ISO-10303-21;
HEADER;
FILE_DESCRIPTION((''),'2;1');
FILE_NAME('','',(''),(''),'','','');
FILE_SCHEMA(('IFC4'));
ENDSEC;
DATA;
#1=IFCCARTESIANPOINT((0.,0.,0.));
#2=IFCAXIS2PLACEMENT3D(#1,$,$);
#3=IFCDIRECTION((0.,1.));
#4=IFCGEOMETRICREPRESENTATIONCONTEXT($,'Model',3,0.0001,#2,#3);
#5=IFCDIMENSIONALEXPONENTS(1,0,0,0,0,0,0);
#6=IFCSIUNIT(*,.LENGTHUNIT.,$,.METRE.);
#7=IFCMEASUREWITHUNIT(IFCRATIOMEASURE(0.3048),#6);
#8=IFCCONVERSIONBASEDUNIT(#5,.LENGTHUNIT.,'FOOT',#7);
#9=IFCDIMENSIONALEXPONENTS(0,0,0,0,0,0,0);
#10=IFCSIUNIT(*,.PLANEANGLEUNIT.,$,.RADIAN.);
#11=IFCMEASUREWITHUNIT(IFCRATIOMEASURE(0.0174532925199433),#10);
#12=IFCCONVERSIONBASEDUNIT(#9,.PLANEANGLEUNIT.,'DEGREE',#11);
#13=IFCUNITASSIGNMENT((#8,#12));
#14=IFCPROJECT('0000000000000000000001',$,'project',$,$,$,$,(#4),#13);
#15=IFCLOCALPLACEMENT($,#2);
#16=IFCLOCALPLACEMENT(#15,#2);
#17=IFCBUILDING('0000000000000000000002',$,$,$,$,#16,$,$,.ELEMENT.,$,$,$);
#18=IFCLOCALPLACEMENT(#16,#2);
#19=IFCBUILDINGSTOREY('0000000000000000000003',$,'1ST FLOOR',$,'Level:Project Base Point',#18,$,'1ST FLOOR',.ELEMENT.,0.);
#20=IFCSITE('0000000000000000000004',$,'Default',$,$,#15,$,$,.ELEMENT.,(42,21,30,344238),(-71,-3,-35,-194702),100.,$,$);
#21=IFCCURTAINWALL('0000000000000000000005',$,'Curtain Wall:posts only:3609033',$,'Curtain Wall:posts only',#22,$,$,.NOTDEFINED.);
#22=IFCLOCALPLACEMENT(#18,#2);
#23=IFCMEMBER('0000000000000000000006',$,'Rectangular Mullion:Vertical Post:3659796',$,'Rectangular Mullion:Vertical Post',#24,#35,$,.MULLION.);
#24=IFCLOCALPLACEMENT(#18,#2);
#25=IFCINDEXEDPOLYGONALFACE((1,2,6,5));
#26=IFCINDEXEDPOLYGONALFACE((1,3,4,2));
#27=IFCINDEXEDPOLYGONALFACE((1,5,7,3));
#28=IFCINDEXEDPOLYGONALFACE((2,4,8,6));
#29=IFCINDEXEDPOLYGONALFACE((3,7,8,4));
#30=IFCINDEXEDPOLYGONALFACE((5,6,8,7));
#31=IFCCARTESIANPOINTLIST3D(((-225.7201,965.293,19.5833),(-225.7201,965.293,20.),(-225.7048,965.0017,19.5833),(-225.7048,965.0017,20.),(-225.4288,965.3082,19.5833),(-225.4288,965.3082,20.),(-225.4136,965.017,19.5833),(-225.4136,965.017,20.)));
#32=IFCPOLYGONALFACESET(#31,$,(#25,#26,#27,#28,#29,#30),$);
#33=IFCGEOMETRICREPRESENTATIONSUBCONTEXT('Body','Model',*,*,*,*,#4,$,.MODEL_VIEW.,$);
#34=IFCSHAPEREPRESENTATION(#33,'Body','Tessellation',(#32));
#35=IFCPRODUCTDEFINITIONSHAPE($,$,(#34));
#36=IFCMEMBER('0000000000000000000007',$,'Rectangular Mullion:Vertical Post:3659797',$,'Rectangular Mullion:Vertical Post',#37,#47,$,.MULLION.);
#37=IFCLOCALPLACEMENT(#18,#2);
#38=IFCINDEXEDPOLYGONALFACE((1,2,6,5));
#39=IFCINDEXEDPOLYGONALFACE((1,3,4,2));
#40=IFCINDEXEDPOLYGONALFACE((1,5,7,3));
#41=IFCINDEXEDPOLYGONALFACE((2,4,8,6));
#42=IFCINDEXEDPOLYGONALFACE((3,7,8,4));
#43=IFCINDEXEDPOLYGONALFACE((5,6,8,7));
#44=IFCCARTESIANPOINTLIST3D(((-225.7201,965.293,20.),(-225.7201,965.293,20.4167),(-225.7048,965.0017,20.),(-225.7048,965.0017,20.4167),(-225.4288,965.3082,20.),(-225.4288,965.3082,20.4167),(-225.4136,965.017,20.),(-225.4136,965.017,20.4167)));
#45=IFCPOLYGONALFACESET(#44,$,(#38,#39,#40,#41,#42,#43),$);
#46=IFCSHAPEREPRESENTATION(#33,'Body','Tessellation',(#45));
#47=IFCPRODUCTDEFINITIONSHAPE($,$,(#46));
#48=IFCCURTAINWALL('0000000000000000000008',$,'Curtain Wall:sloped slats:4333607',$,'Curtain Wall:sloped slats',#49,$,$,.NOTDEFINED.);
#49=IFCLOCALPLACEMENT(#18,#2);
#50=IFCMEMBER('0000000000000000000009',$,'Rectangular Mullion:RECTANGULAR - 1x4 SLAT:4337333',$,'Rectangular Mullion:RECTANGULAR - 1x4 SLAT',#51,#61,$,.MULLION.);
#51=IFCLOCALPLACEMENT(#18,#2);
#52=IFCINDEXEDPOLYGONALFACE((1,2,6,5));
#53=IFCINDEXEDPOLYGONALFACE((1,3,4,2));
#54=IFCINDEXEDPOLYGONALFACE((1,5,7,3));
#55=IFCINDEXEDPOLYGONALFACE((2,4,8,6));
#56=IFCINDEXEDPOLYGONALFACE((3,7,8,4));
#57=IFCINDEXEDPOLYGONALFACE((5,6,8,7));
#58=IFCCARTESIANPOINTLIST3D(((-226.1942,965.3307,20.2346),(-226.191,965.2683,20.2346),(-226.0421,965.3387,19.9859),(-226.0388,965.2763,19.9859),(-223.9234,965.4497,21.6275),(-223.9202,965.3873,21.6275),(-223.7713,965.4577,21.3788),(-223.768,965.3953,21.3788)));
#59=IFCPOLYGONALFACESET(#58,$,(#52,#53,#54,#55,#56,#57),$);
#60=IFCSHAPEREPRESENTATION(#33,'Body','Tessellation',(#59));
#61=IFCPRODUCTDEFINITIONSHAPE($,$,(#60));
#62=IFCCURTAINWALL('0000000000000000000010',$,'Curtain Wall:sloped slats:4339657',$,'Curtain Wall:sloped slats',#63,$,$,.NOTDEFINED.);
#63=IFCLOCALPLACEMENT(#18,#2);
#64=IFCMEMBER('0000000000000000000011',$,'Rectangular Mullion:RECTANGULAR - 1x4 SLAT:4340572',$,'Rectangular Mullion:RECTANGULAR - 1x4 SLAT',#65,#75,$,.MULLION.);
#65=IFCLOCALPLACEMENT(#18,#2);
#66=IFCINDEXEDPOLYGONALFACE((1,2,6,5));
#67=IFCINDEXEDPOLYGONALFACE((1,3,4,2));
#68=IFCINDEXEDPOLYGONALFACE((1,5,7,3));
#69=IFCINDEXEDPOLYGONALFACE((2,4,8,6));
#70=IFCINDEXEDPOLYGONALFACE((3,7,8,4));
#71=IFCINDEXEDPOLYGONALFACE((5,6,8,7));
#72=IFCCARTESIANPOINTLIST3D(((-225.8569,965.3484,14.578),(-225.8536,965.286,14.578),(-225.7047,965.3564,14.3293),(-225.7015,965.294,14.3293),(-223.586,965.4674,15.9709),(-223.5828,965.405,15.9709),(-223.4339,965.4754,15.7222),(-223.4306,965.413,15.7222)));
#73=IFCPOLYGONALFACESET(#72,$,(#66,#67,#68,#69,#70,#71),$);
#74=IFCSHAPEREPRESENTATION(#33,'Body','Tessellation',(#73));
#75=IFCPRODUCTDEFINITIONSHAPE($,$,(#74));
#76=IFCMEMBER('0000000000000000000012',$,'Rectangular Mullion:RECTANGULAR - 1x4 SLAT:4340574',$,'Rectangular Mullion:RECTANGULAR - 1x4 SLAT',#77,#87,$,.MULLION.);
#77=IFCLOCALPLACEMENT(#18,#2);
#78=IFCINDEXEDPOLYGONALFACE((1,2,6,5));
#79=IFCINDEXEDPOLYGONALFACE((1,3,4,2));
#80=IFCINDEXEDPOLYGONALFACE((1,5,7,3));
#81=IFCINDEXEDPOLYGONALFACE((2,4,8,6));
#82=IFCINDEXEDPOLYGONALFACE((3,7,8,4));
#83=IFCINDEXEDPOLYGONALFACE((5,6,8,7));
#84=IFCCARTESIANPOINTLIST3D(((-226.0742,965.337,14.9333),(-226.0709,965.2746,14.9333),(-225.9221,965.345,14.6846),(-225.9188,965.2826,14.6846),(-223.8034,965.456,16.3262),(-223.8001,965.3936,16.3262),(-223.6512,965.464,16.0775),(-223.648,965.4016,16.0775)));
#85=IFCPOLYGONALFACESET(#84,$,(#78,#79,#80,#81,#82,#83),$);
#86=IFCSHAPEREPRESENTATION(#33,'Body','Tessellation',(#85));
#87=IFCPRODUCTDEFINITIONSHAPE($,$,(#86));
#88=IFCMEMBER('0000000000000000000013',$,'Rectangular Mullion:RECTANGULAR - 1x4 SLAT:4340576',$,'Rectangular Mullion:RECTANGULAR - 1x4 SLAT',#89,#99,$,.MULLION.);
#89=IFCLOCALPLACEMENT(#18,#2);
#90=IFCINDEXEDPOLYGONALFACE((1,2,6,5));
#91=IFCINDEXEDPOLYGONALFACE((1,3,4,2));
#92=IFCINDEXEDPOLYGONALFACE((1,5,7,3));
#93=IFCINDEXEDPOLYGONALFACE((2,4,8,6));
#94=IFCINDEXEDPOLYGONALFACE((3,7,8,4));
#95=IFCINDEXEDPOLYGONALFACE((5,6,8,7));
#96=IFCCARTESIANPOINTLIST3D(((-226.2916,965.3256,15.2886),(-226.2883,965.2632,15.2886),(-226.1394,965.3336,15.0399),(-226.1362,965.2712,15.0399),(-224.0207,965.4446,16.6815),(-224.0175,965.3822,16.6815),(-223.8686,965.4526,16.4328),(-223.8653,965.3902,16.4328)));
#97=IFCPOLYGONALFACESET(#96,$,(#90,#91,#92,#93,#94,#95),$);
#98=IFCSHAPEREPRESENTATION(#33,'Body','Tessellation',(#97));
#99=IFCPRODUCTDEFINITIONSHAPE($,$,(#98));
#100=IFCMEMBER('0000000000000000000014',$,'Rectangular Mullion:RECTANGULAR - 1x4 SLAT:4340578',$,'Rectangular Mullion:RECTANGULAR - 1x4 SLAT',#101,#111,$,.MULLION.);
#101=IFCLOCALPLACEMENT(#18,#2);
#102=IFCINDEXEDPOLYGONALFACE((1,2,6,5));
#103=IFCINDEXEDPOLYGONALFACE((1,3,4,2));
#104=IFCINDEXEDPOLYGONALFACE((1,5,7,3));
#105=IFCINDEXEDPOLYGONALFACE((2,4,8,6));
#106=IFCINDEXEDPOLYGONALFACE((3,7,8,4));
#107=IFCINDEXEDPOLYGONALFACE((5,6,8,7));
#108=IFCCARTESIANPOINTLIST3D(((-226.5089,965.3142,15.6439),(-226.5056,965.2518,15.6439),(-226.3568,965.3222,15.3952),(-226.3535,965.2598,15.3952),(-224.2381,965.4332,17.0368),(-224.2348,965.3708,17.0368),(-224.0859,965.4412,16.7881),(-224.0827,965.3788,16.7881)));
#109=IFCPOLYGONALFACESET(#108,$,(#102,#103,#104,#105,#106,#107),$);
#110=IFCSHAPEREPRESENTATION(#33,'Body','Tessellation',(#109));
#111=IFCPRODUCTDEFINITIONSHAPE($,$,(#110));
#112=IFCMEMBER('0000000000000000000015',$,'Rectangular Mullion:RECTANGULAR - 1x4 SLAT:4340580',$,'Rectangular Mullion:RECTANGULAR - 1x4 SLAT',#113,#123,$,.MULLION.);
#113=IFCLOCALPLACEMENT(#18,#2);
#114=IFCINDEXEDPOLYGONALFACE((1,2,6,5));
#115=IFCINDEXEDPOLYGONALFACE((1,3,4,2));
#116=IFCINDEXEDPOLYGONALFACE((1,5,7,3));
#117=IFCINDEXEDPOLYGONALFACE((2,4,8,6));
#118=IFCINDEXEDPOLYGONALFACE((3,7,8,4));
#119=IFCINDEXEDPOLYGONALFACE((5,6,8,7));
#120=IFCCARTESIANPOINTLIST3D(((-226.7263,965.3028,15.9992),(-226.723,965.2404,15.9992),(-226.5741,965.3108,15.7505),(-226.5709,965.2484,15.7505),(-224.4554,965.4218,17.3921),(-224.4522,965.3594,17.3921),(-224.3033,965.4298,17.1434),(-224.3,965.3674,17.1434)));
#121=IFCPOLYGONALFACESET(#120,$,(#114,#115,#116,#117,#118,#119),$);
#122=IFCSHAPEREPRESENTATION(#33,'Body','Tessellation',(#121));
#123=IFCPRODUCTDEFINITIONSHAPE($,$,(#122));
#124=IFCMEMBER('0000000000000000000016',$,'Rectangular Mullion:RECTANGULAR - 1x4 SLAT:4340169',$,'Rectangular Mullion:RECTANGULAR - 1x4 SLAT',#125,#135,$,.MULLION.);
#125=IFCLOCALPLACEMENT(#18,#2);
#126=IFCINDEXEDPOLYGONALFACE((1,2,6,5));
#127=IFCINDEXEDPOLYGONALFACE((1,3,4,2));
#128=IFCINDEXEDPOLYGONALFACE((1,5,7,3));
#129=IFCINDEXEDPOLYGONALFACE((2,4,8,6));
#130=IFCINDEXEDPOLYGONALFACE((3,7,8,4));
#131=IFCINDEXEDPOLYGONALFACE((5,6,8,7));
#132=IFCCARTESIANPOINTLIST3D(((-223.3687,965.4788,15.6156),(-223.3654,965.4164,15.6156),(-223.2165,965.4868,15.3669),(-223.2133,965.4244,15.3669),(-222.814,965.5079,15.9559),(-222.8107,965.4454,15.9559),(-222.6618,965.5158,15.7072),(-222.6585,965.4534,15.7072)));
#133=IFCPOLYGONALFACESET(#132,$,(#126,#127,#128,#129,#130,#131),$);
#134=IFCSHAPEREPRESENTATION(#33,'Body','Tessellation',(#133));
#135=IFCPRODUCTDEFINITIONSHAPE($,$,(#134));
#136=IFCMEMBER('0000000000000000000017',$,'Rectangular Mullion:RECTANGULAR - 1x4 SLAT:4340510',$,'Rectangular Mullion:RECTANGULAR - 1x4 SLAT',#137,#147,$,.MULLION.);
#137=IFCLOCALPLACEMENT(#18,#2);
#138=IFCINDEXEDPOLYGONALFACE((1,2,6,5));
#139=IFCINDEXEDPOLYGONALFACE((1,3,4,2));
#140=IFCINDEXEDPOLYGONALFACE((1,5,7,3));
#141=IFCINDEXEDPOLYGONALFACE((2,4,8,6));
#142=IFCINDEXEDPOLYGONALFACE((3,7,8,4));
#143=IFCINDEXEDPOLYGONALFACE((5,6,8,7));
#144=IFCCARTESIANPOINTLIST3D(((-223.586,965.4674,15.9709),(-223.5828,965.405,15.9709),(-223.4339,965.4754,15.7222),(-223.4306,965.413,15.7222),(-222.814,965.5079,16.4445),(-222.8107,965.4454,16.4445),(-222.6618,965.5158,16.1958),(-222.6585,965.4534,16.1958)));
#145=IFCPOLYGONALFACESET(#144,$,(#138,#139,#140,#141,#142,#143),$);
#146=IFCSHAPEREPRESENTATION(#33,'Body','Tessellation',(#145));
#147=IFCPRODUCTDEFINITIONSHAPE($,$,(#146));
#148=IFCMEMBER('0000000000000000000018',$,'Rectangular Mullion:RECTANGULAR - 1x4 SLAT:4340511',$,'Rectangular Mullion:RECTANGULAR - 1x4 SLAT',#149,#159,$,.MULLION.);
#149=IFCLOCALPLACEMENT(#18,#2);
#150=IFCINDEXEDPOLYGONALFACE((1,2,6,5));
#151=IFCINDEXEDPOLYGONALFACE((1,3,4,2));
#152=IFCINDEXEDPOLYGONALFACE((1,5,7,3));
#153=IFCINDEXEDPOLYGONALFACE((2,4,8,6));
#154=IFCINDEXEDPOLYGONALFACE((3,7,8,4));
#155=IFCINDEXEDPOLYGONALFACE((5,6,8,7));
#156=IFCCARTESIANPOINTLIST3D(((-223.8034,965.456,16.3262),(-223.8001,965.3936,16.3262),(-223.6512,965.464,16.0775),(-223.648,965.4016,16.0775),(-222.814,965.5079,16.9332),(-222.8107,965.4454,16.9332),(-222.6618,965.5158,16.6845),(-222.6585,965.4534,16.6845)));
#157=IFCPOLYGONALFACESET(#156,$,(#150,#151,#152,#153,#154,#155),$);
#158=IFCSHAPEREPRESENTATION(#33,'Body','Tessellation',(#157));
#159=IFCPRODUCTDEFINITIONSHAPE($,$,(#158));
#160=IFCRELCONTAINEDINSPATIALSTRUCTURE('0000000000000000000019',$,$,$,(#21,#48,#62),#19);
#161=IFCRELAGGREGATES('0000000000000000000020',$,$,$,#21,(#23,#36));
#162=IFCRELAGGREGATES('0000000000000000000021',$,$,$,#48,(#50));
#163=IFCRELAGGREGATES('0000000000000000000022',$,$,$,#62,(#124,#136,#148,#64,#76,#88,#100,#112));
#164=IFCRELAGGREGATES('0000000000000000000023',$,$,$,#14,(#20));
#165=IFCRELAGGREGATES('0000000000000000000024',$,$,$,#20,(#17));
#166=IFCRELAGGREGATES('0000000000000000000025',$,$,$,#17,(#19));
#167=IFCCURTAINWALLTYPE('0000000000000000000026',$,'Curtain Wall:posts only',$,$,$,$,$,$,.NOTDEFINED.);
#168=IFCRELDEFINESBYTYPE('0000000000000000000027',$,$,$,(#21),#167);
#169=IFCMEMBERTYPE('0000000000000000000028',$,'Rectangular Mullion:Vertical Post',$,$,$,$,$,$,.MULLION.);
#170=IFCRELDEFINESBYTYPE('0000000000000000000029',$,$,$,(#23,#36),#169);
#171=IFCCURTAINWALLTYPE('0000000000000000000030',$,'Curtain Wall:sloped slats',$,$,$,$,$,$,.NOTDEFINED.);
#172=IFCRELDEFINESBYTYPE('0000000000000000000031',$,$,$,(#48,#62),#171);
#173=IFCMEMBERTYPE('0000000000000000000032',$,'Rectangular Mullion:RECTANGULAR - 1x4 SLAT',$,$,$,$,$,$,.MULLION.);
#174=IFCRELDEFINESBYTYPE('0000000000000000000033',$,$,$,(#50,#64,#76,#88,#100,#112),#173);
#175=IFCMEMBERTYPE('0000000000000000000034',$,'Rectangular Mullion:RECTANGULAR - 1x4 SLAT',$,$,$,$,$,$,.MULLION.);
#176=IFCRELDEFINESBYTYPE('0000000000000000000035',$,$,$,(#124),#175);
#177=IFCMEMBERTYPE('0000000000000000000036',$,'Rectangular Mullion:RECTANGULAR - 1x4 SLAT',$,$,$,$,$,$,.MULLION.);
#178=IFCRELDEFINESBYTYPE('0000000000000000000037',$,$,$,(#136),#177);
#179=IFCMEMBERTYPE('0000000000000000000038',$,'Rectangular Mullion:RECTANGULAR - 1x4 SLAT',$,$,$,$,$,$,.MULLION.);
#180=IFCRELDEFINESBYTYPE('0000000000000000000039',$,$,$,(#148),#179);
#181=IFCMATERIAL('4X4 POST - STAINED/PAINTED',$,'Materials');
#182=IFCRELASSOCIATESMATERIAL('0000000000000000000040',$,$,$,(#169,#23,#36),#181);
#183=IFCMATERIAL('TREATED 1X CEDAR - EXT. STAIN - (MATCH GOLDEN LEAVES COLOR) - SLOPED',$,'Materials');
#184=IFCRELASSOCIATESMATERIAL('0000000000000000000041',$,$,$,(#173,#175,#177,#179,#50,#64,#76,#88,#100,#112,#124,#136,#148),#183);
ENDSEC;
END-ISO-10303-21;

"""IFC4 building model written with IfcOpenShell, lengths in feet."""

from ifc_helpers import new_model, entity, si_unit, converted_unit, direction, frame, frame_2d, origin, origin_2d_with_axis, place, context, subcontext, project, spatial, rectangle, extrude, source, transform, mapped, material, material_profile, profile_set, profile_usage, type_object, type_shapes, element, aggregate, save


model = new_model("IFC4")

# Units and contexts
model_context = context("Model", 3, precision=0.0001, world=origin(), true_north=direction((0.0, 1.0)))
body_context = subcontext(model_context, "Body", "Model", "MODEL_VIEW")
ifc_project = project(units=[converted_unit("LENGTHUNIT", "FOOT", entity("IfcRatioMeasure", 0.3048), si_unit("LENGTHUNIT", "METRE"), dimensions=[1, 0, 0, 0, 0, 0, 0]), converted_unit("PLANEANGLEUNIT", "DEGREE", entity("IfcRatioMeasure", 0.0174532925199433), si_unit("PLANEANGLEUNIT", "RADIAN"), dimensions=[0, 0, 0, 0, 0, 0, 0])], contexts=[model_context])

# Site, building, storey
site_placement = place(None, origin())
site = spatial("IfcSite", under=ifc_project, at=site_placement, Name="Default", CompositionType="ELEMENT", RefLatitude=(42, 21, 30, 344238), RefLongitude=(-71, -3, -35, -194702), RefElevation=100.0)
building_placement = place(site_placement, origin())
building = spatial("IfcBuilding", under=site, at=building_placement, CompositionType="ELEMENT")
storey_placement = place(building_placement, origin())
storey = spatial("IfcBuildingStorey", under=building, at=storey_placement, Name="1ST FLOOR", ObjectType="Level:Project Base Point", LongName="1ST FLOOR", CompositionType="ELEMENT", Elevation=0.0)

# Curtain wall, members
curtain_wall_type_1 = type_object("IfcCurtainWallType", Name="Curtain Wall:posts only", PredefinedType="NOTDEFINED")
curtain_wall_1_placement = place(storey_placement, origin())
curtain_wall_1 = element("IfcCurtainWall", 1, at=curtain_wall_1_placement, inside=storey, type_object=curtain_wall_type_1, Name="Curtain Wall:posts only:3609033", ObjectType="Curtain Wall:posts only", PredefinedType="NOTDEFINED")
ifc_material_1 = material(Name="4X4 POST - STAINED/PAINTED", Category="Materials")
ifc_material_profile_1 = material_profile(ifc_material_1, rectangle(XDim=0.2917, YDim=0.2917, at=origin_2d_with_axis()), Name="Vertical Post")
ifc_profile_set_1 = profile_set([ifc_material_profile_1], Name="Vertical Post")
member_type_1 = type_object("IfcMemberType", Name="Rectangular Mullion:Vertical Post", PredefinedType="MULLION", material=ifc_profile_set_1)
shared_shape_1 = source(origin(), body_context, "Body", "SweptSolid", [
    extrude(rectangle(XDim=0.2917, YDim=0.2917, at=origin_2d_with_axis()), frame((0.0, -0.2083, -0.4167), z_axis=(0.0, 0.0, 1.0), x_axis=(0.0, -1.0, 0.0)), (0.0, 0.0, 1.0), 0.4167),
])
type_shapes(member_type_1, [shared_shape_1])
ifc_profile_usage_1 = profile_usage(ifc_profile_set_1)
member_1_placement = place(storey_placement, frame((-225.5777, 965.363, 19.5833), z_axis=(0.0, 0.0, -1.0), x_axis=(-0.99863, -0.052336, 0.0)))
member_1 = element("IfcMember", 2, at=member_1_placement, type_object=member_type_1, material=ifc_profile_usage_1, Name="Rectangular Mullion:Vertical Post:3659796", ObjectType="Rectangular Mullion:Vertical Post", PredefinedType="MULLION", context=body_context, shape_type="MappedRepresentation", body=[
    mapped(shared_shape_1, transform((0.0, 0.0, 0.0), scale=1.0)),
])
ifc_profile_usage_2 = profile_usage(ifc_profile_set_1)
member_2_placement = place(storey_placement, frame((-225.5777, 965.363, 20.0), z_axis=(0.0, 0.0, -1.0), x_axis=(-0.99863, -0.052336, 0.0)))
member_2 = element("IfcMember", 3, at=member_2_placement, type_object=member_type_1, material=ifc_profile_usage_2, Name="Rectangular Mullion:Vertical Post:3659797", ObjectType="Rectangular Mullion:Vertical Post", PredefinedType="MULLION", context=body_context, shape_type="MappedRepresentation", body=[
    mapped(shared_shape_1, transform((0.0, 0.0, 0.0), scale=1.0)),
])
aggregate(curtain_wall_1, [member_1, member_2])

# Curtain wall, member
curtain_wall_type_2 = type_object("IfcCurtainWallType", Name="Curtain Wall:sloped slats", PredefinedType="NOTDEFINED")
curtain_wall_2_placement = place(storey_placement, origin())
curtain_wall_2 = element("IfcCurtainWall", 4, at=curtain_wall_2_placement, inside=storey, type_object=curtain_wall_type_2, Name="Curtain Wall:sloped slats:4333607", ObjectType="Curtain Wall:sloped slats", PredefinedType="NOTDEFINED")
ifc_material_2 = material(Name="TREATED 1X CEDAR - EXT. STAIN - (MATCH GOLDEN LEAVES COLOR) - SLOPED", Category="Materials")
ifc_material_profile_2 = material_profile(ifc_material_2, rectangle(XDim=0.0625, YDim=0.2917, at=frame_2d((0.0, 0.0), x_axis=(1.0, 0.0))), Name="RECTANGULAR - 1x4 SLAT")
ifc_profile_set_2 = profile_set([ifc_material_profile_2], Name="RECTANGULAR - 1x4 SLAT")
ifc_profile_usage_3 = profile_usage(ifc_profile_set_2)
member_type_2 = type_object("IfcMemberType", Name="Rectangular Mullion:RECTANGULAR - 1x4 SLAT", PredefinedType="MULLION", material=ifc_profile_set_2)
shared_shape_2 = source(origin(), body_context, "Body", "SweptSolid", [
    extrude(rectangle(XDim=0.0625, YDim=0.2917, at=frame_2d((0.0, 0.0), x_axis=(1.0, 0.0))), frame((0.0, 0.0, -2.6667), z_axis=(0.0, 0.0, 1.0), x_axis=(0.0, -1.0, 0.0)), (0.0, 0.0, 1.0), 2.6667),
])
type_shapes(member_type_2, [shared_shape_2])
member_3_placement = place(storey_placement, frame((-226.1165, 965.3035, 20.1102), z_axis=(-0.851559, -0.044628, -0.522356), x_axis=(-0.52164, -0.027338, 0.852727)))
member_3 = element("IfcMember", 5, at=member_3_placement, type_object=member_type_2, material=ifc_profile_usage_3, Name="Rectangular Mullion:RECTANGULAR - 1x4 SLAT:4337333", ObjectType="Rectangular Mullion:RECTANGULAR - 1x4 SLAT", PredefinedType="MULLION", context=body_context, shape_type="MappedRepresentation", body=[
    mapped(shared_shape_2, transform((0.0, 0.0, 0.0), scale=1.0)),
])
aggregate(curtain_wall_2, [member_3])

# Curtain wall, members
curtain_wall_3_placement = place(storey_placement, origin())
curtain_wall_3 = element("IfcCurtainWall", 6, at=curtain_wall_3_placement, inside=storey, type_object=curtain_wall_type_2, Name="Curtain Wall:sloped slats:4339657", ObjectType="Curtain Wall:sloped slats", PredefinedType="NOTDEFINED")
ifc_profile_usage_4 = profile_usage(ifc_profile_set_2)
member_4_placement = place(storey_placement, frame((-225.7792, 965.3212, 14.4536), z_axis=(-0.851559, -0.044628, -0.522356), x_axis=(-0.52164, -0.027338, 0.852727)))
member_4 = element("IfcMember", 7, at=member_4_placement, type_object=member_type_2, material=ifc_profile_usage_4, Name="Rectangular Mullion:RECTANGULAR - 1x4 SLAT:4340572", ObjectType="Rectangular Mullion:RECTANGULAR - 1x4 SLAT", PredefinedType="MULLION", context=body_context, shape_type="MappedRepresentation", body=[
    mapped(shared_shape_2, transform((0.0, 0.0, 0.0), scale=1.0)),
])
ifc_profile_usage_5 = profile_usage(ifc_profile_set_2)
member_5_placement = place(storey_placement, frame((-225.9965, 965.3098, 14.8089), z_axis=(-0.851559, -0.044628, -0.522356), x_axis=(-0.52164, -0.027338, 0.852727)))
member_5 = element("IfcMember", 8, at=member_5_placement, type_object=member_type_2, material=ifc_profile_usage_5, Name="Rectangular Mullion:RECTANGULAR - 1x4 SLAT:4340574", ObjectType="Rectangular Mullion:RECTANGULAR - 1x4 SLAT", PredefinedType="MULLION", context=body_context, shape_type="MappedRepresentation", body=[
    mapped(shared_shape_2, transform((0.0, 0.0, 0.0), scale=1.0)),
])
ifc_profile_usage_6 = profile_usage(ifc_profile_set_2)
member_6_placement = place(storey_placement, frame((-226.2139, 965.2984, 15.1642), z_axis=(-0.851559, -0.044628, -0.522356), x_axis=(-0.52164, -0.027338, 0.852727)))
member_6 = element("IfcMember", 9, at=member_6_placement, type_object=member_type_2, material=ifc_profile_usage_6, Name="Rectangular Mullion:RECTANGULAR - 1x4 SLAT:4340576", ObjectType="Rectangular Mullion:RECTANGULAR - 1x4 SLAT", PredefinedType="MULLION", context=body_context, shape_type="MappedRepresentation", body=[
    mapped(shared_shape_2, transform((0.0, 0.0, 0.0), scale=1.0)),
])
ifc_profile_usage_7 = profile_usage(ifc_profile_set_2)
member_7_placement = place(storey_placement, frame((-226.4312, 965.287, 15.5195), z_axis=(-0.851559, -0.044628, -0.522356), x_axis=(-0.52164, -0.027338, 0.852727)))
member_7 = element("IfcMember", 10, at=member_7_placement, type_object=member_type_2, material=ifc_profile_usage_7, Name="Rectangular Mullion:RECTANGULAR - 1x4 SLAT:4340578", ObjectType="Rectangular Mullion:RECTANGULAR - 1x4 SLAT", PredefinedType="MULLION", context=body_context, shape_type="MappedRepresentation", body=[
    mapped(shared_shape_2, transform((0.0, 0.0, 0.0), scale=1.0)),
])
ifc_profile_usage_8 = profile_usage(ifc_profile_set_2)
member_8_placement = place(storey_placement, frame((-226.6486, 965.2756, 15.8748), z_axis=(-0.851559, -0.044628, -0.522356), x_axis=(-0.52164, -0.027338, 0.852727)))
member_8 = element("IfcMember", 11, at=member_8_placement, type_object=member_type_2, material=ifc_profile_usage_8, Name="Rectangular Mullion:RECTANGULAR - 1x4 SLAT:4340580", ObjectType="Rectangular Mullion:RECTANGULAR - 1x4 SLAT", PredefinedType="MULLION", context=body_context, shape_type="MappedRepresentation", body=[
    mapped(shared_shape_2, transform((0.0, 0.0, 0.0), scale=1.0)),
])
ifc_profile_usage_9 = profile_usage(ifc_profile_set_2)
member_type_3 = type_object("IfcMemberType", Name="Rectangular Mullion:RECTANGULAR - 1x4 SLAT", PredefinedType="MULLION", material=ifc_profile_set_2)
shared_shape_3 = source(origin(), body_context, "Body", "SweptSolid", [
    extrude(rectangle(XDim=0.0625, YDim=0.2917, at=origin_2d_with_axis()), frame((0.0, 0.0, -0.6514), z_axis=(0.0, 0.0, 1.0), x_axis=(0.0, -1.0, 0.0)), (0.0, 0.0, 1.0), 0.6514),
])
type_shapes(member_type_3, [shared_shape_3])
member_9_placement = place(storey_placement, frame((-223.291, 965.4516, 15.4913), z_axis=(-0.851559, -0.044628, -0.522356), x_axis=(-0.52164, -0.027338, 0.852727)))
member_9 = element("IfcMember", 12, at=member_9_placement, type_object=member_type_3, material=ifc_profile_usage_9, Name="Rectangular Mullion:RECTANGULAR - 1x4 SLAT:4340169", ObjectType="Rectangular Mullion:RECTANGULAR - 1x4 SLAT", PredefinedType="MULLION", context=body_context, shape_type="MappedRepresentation", body=[
    mapped(shared_shape_3, transform((0.0, 0.0, 0.0), scale=1.0)),
])
ifc_profile_usage_10 = profile_usage(ifc_profile_set_2)
member_type_4 = type_object("IfcMemberType", Name="Rectangular Mullion:RECTANGULAR - 1x4 SLAT", PredefinedType="MULLION", material=ifc_profile_set_2)
shared_shape_4 = source(origin(), body_context, "Body", "SweptSolid", [
    extrude(rectangle(XDim=0.0625, YDim=0.2917, at=frame_2d((0.0, 0.0), x_axis=(1.0, 0.0))), frame((0.0, 0.0, -0.9067), z_axis=(0.0, 0.0, 1.0), x_axis=(0.0, -1.0, 0.0)), (0.0, 0.0, 1.0), 0.9067),
])
type_shapes(member_type_4, [shared_shape_4])
member_10_placement = place(storey_placement, frame((-223.5083, 965.4402, 15.8466), z_axis=(-0.851559, -0.044628, -0.522356), x_axis=(-0.52164, -0.027338, 0.852727)))
member_10 = element("IfcMember", 13, at=member_10_placement, type_object=member_type_4, material=ifc_profile_usage_10, Name="Rectangular Mullion:RECTANGULAR - 1x4 SLAT:4340510", ObjectType="Rectangular Mullion:RECTANGULAR - 1x4 SLAT", PredefinedType="MULLION", context=body_context, shape_type="MappedRepresentation", body=[
    mapped(shared_shape_4, transform((0.0, 0.0, 0.0), scale=1.0)),
])
ifc_profile_usage_11 = profile_usage(ifc_profile_set_2)
member_type_5 = type_object("IfcMemberType", Name="Rectangular Mullion:RECTANGULAR - 1x4 SLAT", PredefinedType="MULLION", material=ifc_profile_set_2)
shared_shape_5 = source(origin(), body_context, "Body", "SweptSolid", [
    extrude(rectangle(XDim=0.0625, YDim=0.2917, at=frame_2d((0.0, 0.0), x_axis=(1.0, 0.0))), frame((0.0, 0.0, -1.1619), z_axis=(0.0, 0.0, 1.0), x_axis=(0.0, -1.0, 0.0)), (0.0, 0.0, 1.0), 1.1619),
])
type_shapes(member_type_5, [shared_shape_5])
member_11_placement = place(storey_placement, frame((-223.7257, 965.4288, 16.2019), z_axis=(-0.851559, -0.044628, -0.522356), x_axis=(-0.52164, -0.027338, 0.852727)))
member_11 = element("IfcMember", 14, at=member_11_placement, type_object=member_type_5, material=ifc_profile_usage_11, Name="Rectangular Mullion:RECTANGULAR - 1x4 SLAT:4340511", ObjectType="Rectangular Mullion:RECTANGULAR - 1x4 SLAT", PredefinedType="MULLION", context=body_context, shape_type="MappedRepresentation", body=[
    mapped(shared_shape_5, transform((0.0, 0.0, 0.0), scale=1.0)),
])
aggregate(curtain_wall_3, [member_9, member_10, member_11, member_4, member_5, member_6, member_7, member_8])

save(model, "model.ifc")
